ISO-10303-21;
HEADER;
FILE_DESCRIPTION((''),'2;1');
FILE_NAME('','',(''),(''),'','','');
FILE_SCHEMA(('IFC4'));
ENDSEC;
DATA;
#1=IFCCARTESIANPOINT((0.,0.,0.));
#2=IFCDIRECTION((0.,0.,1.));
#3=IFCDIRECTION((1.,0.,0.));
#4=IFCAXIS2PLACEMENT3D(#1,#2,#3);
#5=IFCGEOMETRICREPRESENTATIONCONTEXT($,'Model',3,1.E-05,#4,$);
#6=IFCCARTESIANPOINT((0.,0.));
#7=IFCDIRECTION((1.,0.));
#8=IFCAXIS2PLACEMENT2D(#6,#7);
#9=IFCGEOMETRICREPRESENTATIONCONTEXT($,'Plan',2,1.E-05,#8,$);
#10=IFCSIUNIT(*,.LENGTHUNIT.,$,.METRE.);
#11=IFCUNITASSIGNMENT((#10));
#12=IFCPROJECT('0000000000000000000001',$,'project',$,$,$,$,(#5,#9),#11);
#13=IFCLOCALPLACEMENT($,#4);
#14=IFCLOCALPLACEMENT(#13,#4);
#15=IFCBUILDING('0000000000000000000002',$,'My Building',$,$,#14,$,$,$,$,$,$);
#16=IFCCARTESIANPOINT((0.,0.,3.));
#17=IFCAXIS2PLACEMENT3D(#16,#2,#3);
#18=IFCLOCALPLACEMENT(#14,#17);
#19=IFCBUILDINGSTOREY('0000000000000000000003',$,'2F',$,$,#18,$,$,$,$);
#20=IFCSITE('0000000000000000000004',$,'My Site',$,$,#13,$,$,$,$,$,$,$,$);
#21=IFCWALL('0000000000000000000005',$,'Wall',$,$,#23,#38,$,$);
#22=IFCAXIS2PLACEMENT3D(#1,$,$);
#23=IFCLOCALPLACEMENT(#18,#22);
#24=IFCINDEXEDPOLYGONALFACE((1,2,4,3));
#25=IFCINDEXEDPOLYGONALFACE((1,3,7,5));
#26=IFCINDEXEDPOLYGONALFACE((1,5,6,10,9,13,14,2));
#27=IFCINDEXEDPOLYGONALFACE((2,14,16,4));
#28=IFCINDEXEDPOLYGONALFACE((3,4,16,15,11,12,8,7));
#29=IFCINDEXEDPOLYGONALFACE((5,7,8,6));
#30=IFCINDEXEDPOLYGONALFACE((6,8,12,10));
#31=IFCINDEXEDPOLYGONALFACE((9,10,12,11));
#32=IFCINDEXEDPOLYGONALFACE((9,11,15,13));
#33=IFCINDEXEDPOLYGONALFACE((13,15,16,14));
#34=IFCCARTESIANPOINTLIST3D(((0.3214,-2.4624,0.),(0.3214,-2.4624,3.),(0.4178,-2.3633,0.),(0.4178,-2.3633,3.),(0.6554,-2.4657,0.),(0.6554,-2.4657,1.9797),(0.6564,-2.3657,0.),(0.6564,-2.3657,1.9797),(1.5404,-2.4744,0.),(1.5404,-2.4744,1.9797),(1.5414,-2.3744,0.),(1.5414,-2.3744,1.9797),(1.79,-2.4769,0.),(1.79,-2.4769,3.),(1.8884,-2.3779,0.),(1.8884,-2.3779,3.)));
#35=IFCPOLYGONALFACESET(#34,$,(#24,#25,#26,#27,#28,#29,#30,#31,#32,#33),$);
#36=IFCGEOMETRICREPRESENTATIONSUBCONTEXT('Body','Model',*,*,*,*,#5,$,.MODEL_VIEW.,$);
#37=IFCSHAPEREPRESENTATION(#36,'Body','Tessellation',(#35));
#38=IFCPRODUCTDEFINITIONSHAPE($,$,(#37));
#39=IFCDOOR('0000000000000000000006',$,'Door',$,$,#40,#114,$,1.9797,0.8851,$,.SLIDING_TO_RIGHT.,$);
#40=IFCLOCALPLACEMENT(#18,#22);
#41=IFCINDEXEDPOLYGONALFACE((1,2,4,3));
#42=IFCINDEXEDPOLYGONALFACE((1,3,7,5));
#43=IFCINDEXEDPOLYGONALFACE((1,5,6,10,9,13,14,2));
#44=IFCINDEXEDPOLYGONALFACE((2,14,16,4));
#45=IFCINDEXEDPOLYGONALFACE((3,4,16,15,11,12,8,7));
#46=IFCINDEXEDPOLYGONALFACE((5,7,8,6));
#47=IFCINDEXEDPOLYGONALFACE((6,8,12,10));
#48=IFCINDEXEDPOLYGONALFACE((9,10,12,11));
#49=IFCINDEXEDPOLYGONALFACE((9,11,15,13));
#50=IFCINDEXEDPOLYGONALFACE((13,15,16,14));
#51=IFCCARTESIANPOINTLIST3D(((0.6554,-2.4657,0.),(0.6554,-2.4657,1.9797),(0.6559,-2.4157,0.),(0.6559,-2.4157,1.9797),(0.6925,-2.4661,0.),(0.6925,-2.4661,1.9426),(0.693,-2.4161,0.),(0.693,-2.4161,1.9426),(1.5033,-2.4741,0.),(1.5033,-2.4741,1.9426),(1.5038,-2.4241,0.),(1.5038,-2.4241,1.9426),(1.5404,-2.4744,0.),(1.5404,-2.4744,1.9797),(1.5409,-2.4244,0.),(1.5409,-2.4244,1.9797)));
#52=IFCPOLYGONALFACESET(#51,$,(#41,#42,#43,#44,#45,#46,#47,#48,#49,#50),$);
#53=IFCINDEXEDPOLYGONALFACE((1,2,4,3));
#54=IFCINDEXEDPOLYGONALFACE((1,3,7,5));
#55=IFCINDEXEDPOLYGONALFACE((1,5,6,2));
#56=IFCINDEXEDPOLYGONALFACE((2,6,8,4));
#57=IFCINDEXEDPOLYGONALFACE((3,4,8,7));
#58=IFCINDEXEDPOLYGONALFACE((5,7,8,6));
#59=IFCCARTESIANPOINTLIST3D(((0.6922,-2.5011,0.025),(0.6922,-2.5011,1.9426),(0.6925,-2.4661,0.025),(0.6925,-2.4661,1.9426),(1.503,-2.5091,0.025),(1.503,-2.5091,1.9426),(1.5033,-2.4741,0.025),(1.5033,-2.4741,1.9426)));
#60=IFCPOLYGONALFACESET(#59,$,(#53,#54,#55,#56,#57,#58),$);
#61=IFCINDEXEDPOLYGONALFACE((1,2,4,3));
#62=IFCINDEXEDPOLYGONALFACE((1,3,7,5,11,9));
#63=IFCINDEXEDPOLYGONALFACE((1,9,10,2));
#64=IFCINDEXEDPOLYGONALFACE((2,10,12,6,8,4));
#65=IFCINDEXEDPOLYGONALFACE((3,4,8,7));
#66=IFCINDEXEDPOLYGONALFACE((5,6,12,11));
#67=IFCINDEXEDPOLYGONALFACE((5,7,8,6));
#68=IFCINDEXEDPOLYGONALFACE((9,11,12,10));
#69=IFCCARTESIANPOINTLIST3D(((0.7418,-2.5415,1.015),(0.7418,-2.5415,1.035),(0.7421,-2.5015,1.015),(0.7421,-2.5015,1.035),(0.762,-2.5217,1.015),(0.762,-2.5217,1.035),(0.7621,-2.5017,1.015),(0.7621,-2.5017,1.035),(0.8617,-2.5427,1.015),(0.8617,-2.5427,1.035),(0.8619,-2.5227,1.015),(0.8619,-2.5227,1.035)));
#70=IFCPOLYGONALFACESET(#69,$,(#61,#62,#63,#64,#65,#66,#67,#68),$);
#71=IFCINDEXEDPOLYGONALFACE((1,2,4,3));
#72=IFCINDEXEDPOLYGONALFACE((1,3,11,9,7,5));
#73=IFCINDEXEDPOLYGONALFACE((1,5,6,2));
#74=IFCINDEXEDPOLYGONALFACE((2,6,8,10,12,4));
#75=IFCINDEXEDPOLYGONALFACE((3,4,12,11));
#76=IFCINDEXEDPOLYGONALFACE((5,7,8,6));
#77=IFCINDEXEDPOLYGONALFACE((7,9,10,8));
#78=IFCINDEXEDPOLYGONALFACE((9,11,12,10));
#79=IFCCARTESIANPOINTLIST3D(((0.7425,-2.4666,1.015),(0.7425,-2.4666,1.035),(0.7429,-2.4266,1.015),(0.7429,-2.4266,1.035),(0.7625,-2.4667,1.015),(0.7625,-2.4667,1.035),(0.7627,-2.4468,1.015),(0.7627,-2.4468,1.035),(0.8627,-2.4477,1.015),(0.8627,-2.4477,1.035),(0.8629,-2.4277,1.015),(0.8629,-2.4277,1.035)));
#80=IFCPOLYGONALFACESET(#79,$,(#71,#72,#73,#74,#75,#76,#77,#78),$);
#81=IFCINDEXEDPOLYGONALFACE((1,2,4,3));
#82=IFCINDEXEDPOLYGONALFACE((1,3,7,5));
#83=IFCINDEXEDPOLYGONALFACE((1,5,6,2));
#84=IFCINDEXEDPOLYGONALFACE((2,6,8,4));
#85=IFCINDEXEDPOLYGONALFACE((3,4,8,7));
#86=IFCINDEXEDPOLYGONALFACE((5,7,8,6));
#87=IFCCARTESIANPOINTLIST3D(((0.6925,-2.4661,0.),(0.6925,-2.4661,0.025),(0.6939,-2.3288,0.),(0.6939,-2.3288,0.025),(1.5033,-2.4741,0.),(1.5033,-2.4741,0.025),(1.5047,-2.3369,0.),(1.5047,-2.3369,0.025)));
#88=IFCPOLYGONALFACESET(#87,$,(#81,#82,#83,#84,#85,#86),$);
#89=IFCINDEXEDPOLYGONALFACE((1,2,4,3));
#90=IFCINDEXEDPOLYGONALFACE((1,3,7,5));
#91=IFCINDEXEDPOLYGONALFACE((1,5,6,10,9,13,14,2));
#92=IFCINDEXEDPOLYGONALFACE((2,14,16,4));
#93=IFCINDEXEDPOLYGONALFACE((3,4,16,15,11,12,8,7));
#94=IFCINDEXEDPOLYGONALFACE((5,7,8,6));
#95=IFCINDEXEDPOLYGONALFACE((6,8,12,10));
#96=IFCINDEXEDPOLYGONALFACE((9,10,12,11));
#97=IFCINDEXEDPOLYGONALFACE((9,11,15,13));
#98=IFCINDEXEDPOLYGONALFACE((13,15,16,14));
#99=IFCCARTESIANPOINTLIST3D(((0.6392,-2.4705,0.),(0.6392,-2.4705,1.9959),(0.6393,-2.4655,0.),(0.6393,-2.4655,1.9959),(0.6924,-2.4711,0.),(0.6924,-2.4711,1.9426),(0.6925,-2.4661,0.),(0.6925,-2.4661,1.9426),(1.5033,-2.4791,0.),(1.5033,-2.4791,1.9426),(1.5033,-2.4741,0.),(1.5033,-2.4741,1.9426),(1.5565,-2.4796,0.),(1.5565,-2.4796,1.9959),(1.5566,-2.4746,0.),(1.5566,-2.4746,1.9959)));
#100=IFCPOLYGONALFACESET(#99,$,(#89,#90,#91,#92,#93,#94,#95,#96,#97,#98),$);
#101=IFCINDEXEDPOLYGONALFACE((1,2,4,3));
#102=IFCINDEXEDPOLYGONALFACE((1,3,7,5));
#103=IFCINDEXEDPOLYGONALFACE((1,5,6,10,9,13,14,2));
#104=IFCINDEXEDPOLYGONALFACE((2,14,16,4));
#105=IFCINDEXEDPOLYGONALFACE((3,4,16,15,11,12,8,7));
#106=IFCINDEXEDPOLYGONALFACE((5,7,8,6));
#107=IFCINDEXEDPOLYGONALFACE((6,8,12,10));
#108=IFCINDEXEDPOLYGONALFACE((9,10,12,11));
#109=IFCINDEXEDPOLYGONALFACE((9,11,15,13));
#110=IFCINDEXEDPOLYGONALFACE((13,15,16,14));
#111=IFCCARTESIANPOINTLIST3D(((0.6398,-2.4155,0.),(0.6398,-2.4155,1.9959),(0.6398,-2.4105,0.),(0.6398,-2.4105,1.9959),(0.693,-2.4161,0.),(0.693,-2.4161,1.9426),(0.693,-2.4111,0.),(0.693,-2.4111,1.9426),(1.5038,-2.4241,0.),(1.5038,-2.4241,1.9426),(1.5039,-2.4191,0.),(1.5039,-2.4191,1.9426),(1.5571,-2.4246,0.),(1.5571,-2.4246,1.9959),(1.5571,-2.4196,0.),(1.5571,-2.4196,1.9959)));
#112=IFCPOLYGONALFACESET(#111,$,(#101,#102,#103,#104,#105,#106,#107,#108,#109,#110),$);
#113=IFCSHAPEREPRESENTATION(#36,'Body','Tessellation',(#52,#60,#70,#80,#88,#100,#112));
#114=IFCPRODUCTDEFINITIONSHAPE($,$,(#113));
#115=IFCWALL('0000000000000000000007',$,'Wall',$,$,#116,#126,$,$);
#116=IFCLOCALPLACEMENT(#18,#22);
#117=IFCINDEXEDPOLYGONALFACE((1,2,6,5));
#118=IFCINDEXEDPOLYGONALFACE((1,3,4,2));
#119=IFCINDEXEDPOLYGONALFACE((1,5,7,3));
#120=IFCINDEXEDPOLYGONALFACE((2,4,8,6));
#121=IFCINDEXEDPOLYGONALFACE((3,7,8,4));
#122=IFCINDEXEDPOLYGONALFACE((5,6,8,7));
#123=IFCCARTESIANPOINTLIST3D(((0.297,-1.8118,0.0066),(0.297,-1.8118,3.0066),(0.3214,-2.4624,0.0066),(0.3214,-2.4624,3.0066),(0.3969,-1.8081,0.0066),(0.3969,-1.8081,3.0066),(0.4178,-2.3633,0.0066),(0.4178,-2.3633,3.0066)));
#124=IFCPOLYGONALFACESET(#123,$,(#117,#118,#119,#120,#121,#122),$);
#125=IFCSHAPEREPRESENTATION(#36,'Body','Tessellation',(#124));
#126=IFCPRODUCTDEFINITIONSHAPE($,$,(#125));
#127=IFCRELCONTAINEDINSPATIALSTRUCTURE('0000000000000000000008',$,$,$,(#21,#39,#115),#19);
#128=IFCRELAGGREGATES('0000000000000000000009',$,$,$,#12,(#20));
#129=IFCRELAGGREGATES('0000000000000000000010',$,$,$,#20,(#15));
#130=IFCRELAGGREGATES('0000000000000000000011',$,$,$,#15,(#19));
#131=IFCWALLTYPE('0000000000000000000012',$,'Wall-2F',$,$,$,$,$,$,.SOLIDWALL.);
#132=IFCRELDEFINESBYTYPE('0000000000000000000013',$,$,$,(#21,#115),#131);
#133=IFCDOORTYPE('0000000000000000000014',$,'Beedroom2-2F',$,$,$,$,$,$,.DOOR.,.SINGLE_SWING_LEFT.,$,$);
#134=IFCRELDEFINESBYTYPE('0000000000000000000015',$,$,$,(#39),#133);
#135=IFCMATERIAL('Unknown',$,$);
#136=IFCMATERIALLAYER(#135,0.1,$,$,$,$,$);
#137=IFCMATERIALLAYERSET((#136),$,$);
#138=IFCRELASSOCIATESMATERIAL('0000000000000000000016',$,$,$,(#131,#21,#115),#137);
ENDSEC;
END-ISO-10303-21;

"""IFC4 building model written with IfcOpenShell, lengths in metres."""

from ifc_helpers import new_model, entity, si_unit, frame, origin_with_axes, origin_2d_with_axis, place, context, subcontext, project, spatial, line, indexed_curve, outline, extrude, shape, source, transform, mapped, material, layer, layer_set, layer_usage, type_object, type_shapes, element, fill, save


model = new_model("IFC4")

# Units and contexts
model_context = context("Model", 3, precision=1e-05, world=origin_with_axes())
plan_context = context("Plan", 2, precision=1e-05, world=origin_2d_with_axis())
body_context_1 = subcontext(model_context, "Body", "Model", "MODEL_VIEW")
body_context_2 = subcontext(plan_context, "Body", "Plan", "PLAN_VIEW")
ifc_project = project(units=[si_unit("LENGTHUNIT", "METRE")], contexts=[model_context, plan_context])

# Site, building, storey
site_placement = place(None, origin_with_axes())
site = spatial("IfcSite", under=ifc_project, at=site_placement, Name="My Site")
building_placement = place(site_placement, origin_with_axes())
building = spatial("IfcBuilding", under=site, at=building_placement, Name="My Building")
storey_placement = place(building_placement, frame((0.0, 0.0, 3.0), z_axis=(0.0, 0.0, 1.0), x_axis=(1.0, 0.0, 0.0)))
storey = spatial("IfcBuildingStorey", under=building, at=storey_placement, Name="2F")

# Shared definitions
ifc_material = material(Name="Unknown")

# Shared definitions
ifc_layer_1 = layer(ifc_material, 0.1)
ifc_layer_set_1 = layer_set([ifc_layer_1])
wall_type = type_object("IfcWallType", Name="Wall-2F", PredefinedType="SOLIDWALL", material=ifc_layer_set_1)

# Wall, opening, door
ifc_layer_usage_1 = layer_usage(ifc_layer_set_1, "AXIS2", "POSITIVE", 0.0)
wall_1_placement = place(storey_placement, frame((1.8884, -2.3779, 0.0), z_axis=(0.0, 0.0, 1.0), x_axis=(-0.999951, 0.009882, 0.0)))
wall_1 = element("IfcWall", 1, at=wall_1_placement, inside=storey, type_object=wall_type, material=ifc_layer_usage_1, Name="Wall", context=body_context_1, shape_type="SweptSolid", body=[
    extrude(outline(indexed_curve([(0.0, 0.0), (0.0975, 0.1), (1.5661, 0.1), (1.4707, 0.0)], segments=[line(1, 2, 3, 4, 1)])), origin_with_axes(), (0.0, 0.0, 1.0), 3.0),
])
shared_shape_1 = source(origin_with_axes(), body_context_1, "Body", "SweptSolid", [
    extrude(outline(indexed_curve([(0.0, 0.0), (0.8851, 0.0), (0.8851, 1.9797), (0.0, 1.9797)], segments=[line(1, 2, 3, 4, 1)])), frame((0.0, -0.6, 0.0), z_axis=(0.0, -1.0, 0.0), x_axis=(1.0, 0.0, 0.0)), (0.0, 0.0, -1.0), 1.2),
])
opening_1_placement = place(wall_1_placement, frame((1.2321, 0.1, 0.0), z_axis=(0.0, 0.0, 1.0), x_axis=(-1.0, 0.0, 0.0)))
opening_1 = element("IfcOpeningElement", 2, at=opening_1_placement, cuts=wall_1, PredefinedType="OPENING", context=body_context_1, shape_type="MappedRepresentation", body=[
    mapped(shared_shape_1, transform((0.0, 0.0, 0.0), x_axis=(1.0, 0.0, 0.0), y_axis=(0.0, 1.0, 0.0), z_axis=(0.0, 0.0, 1.0), scale=1.0)),
])
door_type_1 = type_object("IfcDoorType", Name="Beedroom2-2F", OperationType="SINGLE_SWING_LEFT", PredefinedType="DOOR")
shared_shape_2 = source(origin_with_axes(), body_context_1, "Body", "SweptSolid", [
    extrude(outline(indexed_curve([(0.0, 0.0), (0.0, 1.9797), (0.8851, 1.9797), (0.8851, 0.0), (0.848, 0.0), (0.848, 1.9426), (0.0371, 1.9426), (0.0371, 0.0)], segments=[line(1, 2, 3, 4, 5, 6, 7, 8, 1)])), frame((0.0, 0.0, 0.0), z_axis=(0.0, -1.0, 0.0), x_axis=(1.0, 0.0, 0.0)), (0.0, 0.0, -1.0), 0.05),
    extrude(outline(indexed_curve([(0.0, 0.0), (0.8109, 0.0), (0.8109, 0.035), (0.0, 0.035)], segments=[line(1, 2, 3, 4, 1)])), frame((0.0371, -0.035, 0.025), z_axis=(0.0, 0.0, 1.0), x_axis=(1.0, 0.0, 0.0)), (0.0, 0.0, 1.0), 1.9176),
    extrude(outline(indexed_curve([(0.0, 0.0), (0.0, -0.04), (0.12, -0.04), (0.12, -0.02), (0.02, -0.02), (0.02, 0.0)], segments=[line(1, 2, 3, 4, 5, 6, 1)])), frame((0.0871, -0.035, 1.015), z_axis=(0.0, 0.0, 1.0), x_axis=(1.0, 0.0, 0.0)), (0.0, 0.0, 1.0), 0.02),
    extrude(outline(indexed_curve([(0.0, 0.0), (0.0, 0.04), (0.12, 0.04), (0.12, 0.02), (0.02, 0.02), (0.02, 0.0)], segments=[line(1, 2, 3, 4, 5, 6, 1)])), frame((0.0871, 0.0, 1.015), z_axis=(0.0, 0.0, 1.0), x_axis=(1.0, 0.0, 0.0)), (0.0, 0.0, 1.0), 0.02),
    extrude(outline(indexed_curve([(0.0, 0.0), (0.8109, 0.0), (0.8109, 0.1372), (0.0, 0.1372)], segments=[line(1, 2, 3, 4, 1)])), frame((0.0371, 0.0, 0.0), z_axis=(0.0, 0.0, 1.0), x_axis=(1.0, 0.0, 0.0)), (0.0, 0.0, 1.0), 0.025),
    extrude(outline(indexed_curve([(0.0, 0.0), (0.0, 1.9959), (0.9174, 1.9959), (0.9174, 0.0), (0.8641, 0.0), (0.8641, 1.9426), (0.0532, 1.9426), (0.0532, 0.0)], segments=[line(1, 2, 3, 4, 5, 6, 7, 8, 1)])), frame((-0.0162, -0.005, 0.0), z_axis=(0.0, -1.0, 0.0), x_axis=(1.0, 0.0, 0.0)), (0.0, 0.0, -1.0), 0.005),
    extrude(outline(indexed_curve([(0.0, 0.0), (0.0, 1.9959), (0.9174, 1.9959), (0.9174, 0.0), (0.8641, 0.0), (0.8641, 1.9426), (0.0532, 1.9426), (0.0532, 0.0)], segments=[line(1, 2, 3, 4, 5, 6, 7, 8, 1)])), frame((-0.0162, 0.05, 0.0), z_axis=(0.0, -1.0, 0.0), x_axis=(1.0, 0.0, 0.0)), (0.0, 0.0, -1.0), 0.005),
])
shared_shape_3 = source(origin_with_axes(), body_context_2, "Body", "Curve2D", [
    entity("IfcIndexedPolyCurve", entity("IfcCartesianPointList2D", [[0.0, 0.0], [0.0371, 0.0], [0.0371, 0.05], [0.0, 0.05]]), [entity("IfcLineIndex", [1, 2, 3, 4, 1])]),
    entity("IfcIndexedPolyCurve", entity("IfcCartesianPointList2D", [[0.8851, 0.0], [0.848, 0.0], [0.848, 0.05], [0.8851, 0.05]]), [entity("IfcLineIndex", [1, 2, 3, 4, 1])]),
    entity("IfcIndexedPolyCurve", entity("IfcCartesianPointList2D", [[1.2534, -0.035], [0.4425, -0.035], [0.4425, 0.0], [1.2534, 0.0]]), [entity("IfcLineIndex", [1, 2, 3, 4, 1])]),
])
type_shapes(door_type_1, [shared_shape_2, shared_shape_3])
door_1_placement = place(opening_1_placement, frame((0.0, 0.0, 0.0), z_axis=(0.0, 0.0, 1.0), x_axis=(1.0, 0.0, 0.0)))
door_1 = element("IfcDoor", 3, at=door_1_placement, inside=storey, type_object=door_type_1, Name="Door", OperationType="SLIDING_TO_RIGHT", OverallHeight=1.9797, OverallWidth=0.8851, shapes=[
    shape(body_context_1, "Body", "MappedRepresentation", [mapped(shared_shape_2, transform((0.0, 0.0, 0.0), x_axis=(1.0, 0.0, 0.0), y_axis=(0.0, 1.0, 0.0), z_axis=(0.0, 0.0, 1.0), scale=1.0))]),
    shape(body_context_2, "Body", "MappedRepresentation", [mapped(shared_shape_3, transform((0.0, 0.0, 0.0), x_axis=(1.0, 0.0, 0.0), y_axis=(0.0, 1.0, 0.0), z_axis=(0.0, 0.0, 1.0), scale=1.0))]),
])
fill(opening_1, door_1)

# Wall
ifc_layer_usage_2 = layer_usage(ifc_layer_set_1, "AXIS2", "POSITIVE", 0.0)
wall_2_placement = place(storey_placement, frame((0.4178, -2.3633, 0.0066), z_axis=(0.0, 0.0, 1.0), x_axis=(-0.037573, 0.999294, 0.0)))
element("IfcWall", 4, at=wall_2_placement, inside=storey, type_object=wall_type, material=ifc_layer_usage_2, Name="Wall", context=body_context_1, shape_type="SweptSolid", body=[
    extrude(outline(indexed_curve([(0.0, 0.0), (-0.0954, 0.1), (0.5556, 0.1), (0.5556, 0.0)], segments=[line(1, 2, 3, 4, 1)])), origin_with_axes(), (0.0, 0.0, 1.0), 3.0),
])

save(model, "model.ifc")
